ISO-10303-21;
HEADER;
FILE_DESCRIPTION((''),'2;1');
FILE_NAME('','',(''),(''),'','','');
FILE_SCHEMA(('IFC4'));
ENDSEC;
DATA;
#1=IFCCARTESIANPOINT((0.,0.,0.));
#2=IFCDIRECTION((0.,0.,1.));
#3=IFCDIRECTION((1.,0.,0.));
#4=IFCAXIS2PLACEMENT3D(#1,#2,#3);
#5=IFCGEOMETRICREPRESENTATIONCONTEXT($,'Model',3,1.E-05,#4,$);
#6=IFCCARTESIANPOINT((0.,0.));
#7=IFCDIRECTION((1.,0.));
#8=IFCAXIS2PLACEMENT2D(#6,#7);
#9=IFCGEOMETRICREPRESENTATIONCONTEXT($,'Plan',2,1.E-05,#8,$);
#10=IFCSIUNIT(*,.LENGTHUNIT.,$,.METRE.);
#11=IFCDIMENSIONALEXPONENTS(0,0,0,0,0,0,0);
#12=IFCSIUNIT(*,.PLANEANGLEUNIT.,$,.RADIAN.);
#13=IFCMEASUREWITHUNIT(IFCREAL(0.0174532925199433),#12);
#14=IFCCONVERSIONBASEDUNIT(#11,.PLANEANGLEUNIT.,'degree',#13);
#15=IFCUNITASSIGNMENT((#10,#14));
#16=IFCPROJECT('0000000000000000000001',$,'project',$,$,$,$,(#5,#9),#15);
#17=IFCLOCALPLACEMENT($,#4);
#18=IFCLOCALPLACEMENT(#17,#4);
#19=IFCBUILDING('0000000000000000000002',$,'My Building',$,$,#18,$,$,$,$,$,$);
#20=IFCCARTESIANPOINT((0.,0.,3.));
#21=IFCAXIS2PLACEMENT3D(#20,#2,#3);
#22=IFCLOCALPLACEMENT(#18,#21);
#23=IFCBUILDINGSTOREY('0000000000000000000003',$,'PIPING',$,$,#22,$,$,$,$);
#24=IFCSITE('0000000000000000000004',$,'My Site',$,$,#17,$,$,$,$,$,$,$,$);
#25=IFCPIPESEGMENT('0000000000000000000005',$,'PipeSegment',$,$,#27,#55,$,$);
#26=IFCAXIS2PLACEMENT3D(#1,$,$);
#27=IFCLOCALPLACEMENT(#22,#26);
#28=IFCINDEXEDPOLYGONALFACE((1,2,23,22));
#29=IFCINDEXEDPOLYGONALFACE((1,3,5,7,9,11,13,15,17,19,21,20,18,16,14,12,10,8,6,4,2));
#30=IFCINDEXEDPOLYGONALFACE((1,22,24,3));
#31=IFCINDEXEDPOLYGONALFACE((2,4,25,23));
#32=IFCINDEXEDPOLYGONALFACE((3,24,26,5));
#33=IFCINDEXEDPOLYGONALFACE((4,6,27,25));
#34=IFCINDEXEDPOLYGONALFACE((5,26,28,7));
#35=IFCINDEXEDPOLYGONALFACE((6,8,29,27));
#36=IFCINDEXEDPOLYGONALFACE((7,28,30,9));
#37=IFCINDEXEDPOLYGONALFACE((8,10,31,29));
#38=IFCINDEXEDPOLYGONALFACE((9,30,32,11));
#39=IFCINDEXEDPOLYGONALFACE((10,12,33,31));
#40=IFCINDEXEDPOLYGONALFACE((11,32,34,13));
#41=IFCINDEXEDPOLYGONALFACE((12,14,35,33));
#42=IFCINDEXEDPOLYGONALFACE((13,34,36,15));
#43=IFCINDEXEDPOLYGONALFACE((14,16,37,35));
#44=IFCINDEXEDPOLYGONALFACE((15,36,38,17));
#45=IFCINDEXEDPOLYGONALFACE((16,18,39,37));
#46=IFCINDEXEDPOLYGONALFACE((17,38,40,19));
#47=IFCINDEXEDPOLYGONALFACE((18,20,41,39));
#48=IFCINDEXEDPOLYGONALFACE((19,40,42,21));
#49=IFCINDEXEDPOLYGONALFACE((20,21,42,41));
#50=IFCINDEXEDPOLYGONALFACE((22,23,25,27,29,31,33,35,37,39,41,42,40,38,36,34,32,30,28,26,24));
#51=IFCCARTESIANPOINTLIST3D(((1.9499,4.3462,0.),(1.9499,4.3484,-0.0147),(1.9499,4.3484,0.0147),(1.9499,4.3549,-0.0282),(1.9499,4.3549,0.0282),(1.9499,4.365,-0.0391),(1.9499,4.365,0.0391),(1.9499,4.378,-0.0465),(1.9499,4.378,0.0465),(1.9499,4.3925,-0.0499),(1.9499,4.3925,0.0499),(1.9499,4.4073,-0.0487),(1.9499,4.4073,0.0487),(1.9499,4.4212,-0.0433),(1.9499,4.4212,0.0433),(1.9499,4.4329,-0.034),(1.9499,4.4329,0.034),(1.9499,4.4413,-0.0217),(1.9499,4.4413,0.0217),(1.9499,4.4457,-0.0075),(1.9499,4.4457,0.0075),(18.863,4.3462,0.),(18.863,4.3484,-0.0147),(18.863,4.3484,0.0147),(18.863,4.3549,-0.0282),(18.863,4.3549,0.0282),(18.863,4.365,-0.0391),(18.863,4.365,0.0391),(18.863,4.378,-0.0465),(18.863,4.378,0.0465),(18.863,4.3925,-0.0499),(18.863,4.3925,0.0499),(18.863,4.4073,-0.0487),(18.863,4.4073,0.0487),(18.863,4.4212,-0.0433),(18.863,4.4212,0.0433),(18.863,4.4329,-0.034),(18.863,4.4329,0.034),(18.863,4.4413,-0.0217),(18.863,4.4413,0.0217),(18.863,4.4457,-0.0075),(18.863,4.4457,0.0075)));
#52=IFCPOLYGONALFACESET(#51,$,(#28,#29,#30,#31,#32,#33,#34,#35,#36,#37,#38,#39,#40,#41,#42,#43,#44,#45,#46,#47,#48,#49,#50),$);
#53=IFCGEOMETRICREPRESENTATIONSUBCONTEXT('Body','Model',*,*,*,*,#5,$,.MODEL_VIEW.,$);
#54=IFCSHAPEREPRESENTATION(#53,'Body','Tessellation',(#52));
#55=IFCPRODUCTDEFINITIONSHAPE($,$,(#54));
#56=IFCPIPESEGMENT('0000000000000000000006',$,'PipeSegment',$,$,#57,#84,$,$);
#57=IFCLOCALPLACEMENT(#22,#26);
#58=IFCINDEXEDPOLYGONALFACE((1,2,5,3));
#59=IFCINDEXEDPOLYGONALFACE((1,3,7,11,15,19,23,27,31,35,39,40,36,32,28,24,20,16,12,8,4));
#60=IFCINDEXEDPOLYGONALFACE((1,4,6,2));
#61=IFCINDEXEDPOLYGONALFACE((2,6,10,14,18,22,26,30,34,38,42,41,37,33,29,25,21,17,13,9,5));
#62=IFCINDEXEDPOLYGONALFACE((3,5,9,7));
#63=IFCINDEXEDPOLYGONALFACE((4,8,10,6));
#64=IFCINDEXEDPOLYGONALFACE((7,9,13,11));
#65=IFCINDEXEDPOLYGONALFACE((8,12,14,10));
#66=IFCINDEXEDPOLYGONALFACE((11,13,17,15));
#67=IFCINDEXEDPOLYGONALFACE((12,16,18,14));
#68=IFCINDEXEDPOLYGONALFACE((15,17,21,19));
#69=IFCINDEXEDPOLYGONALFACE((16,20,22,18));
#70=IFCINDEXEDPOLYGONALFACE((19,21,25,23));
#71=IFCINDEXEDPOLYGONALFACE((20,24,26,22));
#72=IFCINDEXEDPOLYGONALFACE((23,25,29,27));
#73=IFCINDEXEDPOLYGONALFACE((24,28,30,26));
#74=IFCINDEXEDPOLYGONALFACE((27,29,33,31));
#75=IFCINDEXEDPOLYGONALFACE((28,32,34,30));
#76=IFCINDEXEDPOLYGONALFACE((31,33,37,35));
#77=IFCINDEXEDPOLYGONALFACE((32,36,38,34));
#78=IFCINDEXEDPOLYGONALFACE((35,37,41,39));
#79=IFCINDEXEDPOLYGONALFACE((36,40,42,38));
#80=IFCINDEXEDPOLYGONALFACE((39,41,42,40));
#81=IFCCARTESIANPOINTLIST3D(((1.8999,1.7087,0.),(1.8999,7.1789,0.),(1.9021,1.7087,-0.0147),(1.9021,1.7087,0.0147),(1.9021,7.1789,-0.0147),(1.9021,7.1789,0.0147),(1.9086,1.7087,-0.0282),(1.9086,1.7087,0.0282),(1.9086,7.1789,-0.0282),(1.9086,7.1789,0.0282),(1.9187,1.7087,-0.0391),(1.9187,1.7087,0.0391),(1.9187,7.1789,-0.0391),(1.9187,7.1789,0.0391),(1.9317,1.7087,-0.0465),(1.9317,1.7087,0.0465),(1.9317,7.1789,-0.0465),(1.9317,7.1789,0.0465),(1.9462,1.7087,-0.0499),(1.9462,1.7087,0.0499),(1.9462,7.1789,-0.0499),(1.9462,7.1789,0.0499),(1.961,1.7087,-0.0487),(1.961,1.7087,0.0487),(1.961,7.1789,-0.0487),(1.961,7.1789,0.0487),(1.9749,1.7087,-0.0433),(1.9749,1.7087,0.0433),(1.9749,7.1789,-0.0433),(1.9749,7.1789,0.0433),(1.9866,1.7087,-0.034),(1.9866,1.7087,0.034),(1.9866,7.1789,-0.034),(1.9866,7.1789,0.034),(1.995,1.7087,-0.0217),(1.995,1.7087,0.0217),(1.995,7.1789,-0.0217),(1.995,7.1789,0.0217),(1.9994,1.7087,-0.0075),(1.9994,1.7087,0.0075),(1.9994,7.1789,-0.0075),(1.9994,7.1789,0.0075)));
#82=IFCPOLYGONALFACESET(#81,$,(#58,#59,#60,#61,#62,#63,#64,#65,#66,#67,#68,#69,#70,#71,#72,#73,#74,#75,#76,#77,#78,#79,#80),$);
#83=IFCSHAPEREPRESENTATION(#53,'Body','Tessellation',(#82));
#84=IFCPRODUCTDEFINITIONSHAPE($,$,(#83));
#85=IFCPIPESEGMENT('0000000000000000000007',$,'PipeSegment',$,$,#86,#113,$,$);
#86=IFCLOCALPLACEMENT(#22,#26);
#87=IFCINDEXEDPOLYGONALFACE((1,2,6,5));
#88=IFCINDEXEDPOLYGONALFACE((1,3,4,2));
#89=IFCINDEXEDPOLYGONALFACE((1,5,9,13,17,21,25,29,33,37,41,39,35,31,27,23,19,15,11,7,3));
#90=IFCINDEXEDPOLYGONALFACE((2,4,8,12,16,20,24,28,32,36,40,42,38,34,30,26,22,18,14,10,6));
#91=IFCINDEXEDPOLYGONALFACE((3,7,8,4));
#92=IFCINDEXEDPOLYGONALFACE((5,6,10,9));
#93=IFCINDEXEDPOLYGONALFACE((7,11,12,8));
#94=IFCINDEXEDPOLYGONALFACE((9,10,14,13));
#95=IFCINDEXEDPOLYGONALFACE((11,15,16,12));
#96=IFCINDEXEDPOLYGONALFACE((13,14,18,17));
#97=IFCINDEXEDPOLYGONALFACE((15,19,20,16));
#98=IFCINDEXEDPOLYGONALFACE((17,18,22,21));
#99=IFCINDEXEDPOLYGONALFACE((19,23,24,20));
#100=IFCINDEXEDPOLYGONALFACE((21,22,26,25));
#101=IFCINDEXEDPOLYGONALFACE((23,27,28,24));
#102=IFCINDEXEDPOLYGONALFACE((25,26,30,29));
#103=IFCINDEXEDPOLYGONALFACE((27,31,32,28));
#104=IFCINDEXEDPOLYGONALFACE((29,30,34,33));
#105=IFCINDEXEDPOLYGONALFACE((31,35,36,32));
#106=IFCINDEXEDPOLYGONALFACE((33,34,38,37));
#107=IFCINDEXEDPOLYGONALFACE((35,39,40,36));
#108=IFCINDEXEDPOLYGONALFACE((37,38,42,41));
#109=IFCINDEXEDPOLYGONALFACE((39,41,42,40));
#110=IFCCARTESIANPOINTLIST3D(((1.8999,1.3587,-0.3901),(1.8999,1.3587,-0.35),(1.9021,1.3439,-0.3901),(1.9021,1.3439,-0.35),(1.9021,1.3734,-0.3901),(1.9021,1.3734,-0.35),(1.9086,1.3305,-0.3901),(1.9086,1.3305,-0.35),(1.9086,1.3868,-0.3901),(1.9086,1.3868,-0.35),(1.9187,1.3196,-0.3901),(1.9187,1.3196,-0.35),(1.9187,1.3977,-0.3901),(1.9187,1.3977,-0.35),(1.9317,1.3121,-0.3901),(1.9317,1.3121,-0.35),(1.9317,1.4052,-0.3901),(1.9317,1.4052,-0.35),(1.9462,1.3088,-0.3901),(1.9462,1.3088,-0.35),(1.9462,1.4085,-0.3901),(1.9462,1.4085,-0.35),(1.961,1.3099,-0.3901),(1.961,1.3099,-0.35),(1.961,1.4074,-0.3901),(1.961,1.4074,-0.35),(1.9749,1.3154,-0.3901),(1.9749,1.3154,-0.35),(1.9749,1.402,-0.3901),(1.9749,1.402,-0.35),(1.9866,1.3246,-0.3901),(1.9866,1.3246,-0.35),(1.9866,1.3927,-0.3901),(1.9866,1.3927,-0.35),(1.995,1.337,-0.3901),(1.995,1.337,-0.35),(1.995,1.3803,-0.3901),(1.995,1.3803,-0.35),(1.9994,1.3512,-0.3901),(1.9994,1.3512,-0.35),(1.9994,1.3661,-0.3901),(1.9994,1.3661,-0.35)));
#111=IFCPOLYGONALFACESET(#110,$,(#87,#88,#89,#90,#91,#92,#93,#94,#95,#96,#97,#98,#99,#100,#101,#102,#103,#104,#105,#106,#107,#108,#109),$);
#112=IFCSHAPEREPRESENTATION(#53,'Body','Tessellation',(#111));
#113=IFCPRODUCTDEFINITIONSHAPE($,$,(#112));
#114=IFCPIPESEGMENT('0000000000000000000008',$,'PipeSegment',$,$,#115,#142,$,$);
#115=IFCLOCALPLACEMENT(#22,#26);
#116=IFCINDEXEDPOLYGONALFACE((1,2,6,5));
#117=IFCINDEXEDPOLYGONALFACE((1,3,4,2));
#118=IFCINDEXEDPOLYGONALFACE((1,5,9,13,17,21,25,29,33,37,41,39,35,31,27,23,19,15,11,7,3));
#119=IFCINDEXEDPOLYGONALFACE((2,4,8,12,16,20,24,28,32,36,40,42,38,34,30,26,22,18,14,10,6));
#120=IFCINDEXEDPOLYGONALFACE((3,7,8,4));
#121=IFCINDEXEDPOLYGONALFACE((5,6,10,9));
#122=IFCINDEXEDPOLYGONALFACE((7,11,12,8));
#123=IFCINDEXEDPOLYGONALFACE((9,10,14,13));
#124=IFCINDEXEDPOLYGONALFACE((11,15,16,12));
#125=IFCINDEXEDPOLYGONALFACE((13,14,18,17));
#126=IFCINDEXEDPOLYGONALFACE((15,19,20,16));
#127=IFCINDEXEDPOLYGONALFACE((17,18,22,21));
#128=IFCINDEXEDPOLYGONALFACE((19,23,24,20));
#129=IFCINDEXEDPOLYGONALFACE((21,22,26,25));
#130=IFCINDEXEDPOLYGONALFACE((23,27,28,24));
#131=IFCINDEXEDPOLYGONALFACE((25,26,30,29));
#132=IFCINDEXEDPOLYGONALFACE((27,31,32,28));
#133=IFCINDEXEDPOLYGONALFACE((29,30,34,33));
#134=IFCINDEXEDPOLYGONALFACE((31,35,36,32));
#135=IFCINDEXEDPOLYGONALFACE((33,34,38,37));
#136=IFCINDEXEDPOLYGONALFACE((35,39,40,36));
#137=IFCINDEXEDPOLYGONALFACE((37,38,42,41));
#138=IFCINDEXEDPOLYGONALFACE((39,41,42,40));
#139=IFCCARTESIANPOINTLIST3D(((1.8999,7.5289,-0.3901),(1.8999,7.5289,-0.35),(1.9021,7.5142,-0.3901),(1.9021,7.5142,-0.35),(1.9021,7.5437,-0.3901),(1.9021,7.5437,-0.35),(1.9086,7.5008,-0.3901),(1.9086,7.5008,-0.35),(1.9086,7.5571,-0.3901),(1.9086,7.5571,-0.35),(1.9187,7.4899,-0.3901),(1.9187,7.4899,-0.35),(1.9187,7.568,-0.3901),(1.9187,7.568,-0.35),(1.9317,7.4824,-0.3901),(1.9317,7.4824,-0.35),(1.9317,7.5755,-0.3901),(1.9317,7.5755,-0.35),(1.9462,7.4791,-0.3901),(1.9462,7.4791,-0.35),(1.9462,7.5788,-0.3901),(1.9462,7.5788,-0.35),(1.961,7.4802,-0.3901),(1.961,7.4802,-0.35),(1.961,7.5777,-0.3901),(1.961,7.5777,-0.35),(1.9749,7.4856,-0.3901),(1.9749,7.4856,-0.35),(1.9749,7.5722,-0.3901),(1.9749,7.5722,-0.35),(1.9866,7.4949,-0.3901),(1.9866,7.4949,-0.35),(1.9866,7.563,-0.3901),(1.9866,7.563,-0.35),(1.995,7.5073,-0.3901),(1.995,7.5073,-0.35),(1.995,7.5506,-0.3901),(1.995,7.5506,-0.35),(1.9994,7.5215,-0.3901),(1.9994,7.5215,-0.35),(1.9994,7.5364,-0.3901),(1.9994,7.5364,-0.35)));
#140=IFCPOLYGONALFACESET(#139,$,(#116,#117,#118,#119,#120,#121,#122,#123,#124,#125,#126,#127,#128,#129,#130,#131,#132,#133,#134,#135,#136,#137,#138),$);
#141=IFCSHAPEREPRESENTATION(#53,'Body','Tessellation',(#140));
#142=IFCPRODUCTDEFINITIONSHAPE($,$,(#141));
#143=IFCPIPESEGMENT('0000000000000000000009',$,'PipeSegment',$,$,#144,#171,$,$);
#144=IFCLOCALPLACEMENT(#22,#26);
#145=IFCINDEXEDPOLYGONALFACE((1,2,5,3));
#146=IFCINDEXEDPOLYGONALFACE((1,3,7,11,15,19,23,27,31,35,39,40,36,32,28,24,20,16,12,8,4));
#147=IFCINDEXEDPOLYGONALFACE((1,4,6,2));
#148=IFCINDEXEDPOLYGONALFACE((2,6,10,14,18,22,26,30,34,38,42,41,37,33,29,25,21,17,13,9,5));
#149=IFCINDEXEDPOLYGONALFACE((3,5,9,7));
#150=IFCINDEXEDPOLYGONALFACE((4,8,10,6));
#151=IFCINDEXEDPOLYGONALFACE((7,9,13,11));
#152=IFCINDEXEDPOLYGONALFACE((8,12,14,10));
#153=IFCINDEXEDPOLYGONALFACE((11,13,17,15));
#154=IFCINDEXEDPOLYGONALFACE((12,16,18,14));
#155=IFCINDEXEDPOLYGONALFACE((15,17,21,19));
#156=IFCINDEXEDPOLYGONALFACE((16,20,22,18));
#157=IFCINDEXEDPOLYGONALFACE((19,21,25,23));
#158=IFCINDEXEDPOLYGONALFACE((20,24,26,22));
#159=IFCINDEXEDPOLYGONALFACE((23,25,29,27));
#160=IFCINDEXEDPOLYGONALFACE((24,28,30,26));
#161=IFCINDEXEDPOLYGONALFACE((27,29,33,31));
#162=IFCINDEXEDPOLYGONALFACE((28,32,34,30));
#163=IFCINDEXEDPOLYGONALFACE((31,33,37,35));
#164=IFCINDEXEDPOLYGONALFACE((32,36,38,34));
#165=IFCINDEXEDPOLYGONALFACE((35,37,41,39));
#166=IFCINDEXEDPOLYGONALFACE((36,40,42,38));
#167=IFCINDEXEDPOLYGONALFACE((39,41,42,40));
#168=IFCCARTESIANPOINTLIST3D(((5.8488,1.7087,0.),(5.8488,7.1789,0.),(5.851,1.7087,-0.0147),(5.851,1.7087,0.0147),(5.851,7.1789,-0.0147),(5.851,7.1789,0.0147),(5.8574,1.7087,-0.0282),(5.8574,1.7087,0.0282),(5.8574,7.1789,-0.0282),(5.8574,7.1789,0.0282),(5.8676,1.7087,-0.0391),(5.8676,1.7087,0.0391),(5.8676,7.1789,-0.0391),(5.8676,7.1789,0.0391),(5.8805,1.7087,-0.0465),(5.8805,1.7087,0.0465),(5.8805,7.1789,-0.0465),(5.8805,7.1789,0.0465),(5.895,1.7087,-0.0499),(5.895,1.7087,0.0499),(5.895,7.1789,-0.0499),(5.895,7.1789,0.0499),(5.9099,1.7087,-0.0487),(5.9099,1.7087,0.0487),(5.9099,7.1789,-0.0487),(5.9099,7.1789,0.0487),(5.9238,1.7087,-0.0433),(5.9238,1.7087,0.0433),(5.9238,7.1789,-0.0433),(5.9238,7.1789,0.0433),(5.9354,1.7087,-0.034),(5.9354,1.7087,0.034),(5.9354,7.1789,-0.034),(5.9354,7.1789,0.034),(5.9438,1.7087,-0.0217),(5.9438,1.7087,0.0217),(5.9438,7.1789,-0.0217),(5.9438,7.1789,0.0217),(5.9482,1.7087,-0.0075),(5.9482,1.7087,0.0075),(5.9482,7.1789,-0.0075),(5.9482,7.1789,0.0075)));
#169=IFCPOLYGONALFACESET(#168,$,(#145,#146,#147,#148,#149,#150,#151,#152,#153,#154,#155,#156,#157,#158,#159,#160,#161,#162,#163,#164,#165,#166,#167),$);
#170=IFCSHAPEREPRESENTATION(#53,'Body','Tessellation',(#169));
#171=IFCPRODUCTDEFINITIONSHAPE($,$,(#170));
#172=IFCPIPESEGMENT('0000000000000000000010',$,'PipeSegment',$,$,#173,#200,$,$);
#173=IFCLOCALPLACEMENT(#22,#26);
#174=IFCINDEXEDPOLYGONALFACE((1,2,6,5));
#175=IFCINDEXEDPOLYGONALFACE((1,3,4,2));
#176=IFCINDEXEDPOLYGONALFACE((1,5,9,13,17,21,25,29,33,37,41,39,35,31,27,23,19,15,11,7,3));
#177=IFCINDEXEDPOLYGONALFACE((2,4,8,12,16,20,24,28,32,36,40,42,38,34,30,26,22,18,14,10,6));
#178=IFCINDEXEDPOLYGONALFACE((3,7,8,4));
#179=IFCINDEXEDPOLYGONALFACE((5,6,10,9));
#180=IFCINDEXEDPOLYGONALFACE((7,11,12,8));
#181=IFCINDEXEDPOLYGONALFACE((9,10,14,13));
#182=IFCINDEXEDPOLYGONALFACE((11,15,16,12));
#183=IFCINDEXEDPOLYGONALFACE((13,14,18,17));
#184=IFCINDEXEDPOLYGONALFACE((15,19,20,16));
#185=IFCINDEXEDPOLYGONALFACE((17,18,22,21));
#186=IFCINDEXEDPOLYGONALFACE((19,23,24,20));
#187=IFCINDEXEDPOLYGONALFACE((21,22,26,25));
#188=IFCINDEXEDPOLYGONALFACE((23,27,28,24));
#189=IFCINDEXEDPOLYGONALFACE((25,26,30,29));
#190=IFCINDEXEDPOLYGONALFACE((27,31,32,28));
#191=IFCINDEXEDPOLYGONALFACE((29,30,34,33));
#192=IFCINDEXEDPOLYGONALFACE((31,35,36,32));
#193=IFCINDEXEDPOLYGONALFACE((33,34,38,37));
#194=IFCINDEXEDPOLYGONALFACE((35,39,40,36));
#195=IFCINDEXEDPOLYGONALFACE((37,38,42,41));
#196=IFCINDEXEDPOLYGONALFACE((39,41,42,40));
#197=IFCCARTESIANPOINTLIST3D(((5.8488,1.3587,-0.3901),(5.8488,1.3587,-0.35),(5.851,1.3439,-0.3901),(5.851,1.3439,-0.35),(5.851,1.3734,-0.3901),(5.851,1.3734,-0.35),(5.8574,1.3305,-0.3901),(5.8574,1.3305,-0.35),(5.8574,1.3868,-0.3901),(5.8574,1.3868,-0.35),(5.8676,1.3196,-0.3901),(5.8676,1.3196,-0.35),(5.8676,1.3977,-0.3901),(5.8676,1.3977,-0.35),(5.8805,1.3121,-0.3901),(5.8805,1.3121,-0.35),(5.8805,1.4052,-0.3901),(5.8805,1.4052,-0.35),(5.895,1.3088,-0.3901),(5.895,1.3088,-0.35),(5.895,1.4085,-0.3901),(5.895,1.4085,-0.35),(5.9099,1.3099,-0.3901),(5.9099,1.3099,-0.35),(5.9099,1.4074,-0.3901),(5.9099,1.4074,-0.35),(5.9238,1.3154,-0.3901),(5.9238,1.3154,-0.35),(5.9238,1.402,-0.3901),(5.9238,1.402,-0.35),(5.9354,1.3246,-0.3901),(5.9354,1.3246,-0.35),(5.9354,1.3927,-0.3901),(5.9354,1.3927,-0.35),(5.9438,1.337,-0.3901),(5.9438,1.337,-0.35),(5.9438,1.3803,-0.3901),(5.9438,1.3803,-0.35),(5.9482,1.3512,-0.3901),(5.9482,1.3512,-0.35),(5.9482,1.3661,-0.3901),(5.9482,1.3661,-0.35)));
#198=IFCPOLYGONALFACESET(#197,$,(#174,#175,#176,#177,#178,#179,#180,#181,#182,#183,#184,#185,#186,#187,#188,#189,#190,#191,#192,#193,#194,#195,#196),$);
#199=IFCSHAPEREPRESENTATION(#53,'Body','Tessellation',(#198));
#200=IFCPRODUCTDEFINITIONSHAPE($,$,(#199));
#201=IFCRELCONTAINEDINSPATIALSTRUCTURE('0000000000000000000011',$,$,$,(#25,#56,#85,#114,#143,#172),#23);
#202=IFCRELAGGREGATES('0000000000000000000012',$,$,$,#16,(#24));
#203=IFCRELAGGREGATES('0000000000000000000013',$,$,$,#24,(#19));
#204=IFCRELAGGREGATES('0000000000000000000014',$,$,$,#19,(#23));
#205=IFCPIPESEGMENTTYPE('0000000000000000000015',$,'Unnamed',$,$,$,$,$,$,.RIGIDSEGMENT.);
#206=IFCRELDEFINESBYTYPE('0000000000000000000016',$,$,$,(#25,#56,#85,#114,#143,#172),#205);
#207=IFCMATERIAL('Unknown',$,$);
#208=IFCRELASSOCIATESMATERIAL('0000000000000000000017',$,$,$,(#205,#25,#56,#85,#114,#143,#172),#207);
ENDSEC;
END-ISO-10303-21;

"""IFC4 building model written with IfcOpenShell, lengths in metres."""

from ifc_helpers import new_model, entity, si_unit, converted_unit, frame, origin_with_axes, origin_2d_with_axis, place, context, subcontext, project, spatial, circle, extrude, material, material_profile, profile_set, profile_usage, type_object, element, save


model = new_model("IFC4")

# Units and contexts
model_context = context("Model", 3, precision=1e-05, world=origin_with_axes())
plan_context = context("Plan", 2, precision=1e-05, world=origin_2d_with_axis())
body_context = subcontext(model_context, "Body", "Model", "MODEL_VIEW")
ifc_project = project(units=[si_unit("LENGTHUNIT", "METRE"), converted_unit("PLANEANGLEUNIT", "degree", entity("IfcReal", 0.0174532925199433), si_unit("PLANEANGLEUNIT", "RADIAN"), dimensions=[0, 0, 0, 0, 0, 0, 0])], contexts=[model_context, plan_context])

# Site, building, storey
site_placement = place(None, origin_with_axes())
site = spatial("IfcSite", under=ifc_project, at=site_placement, Name="My Site")
building_placement = place(site_placement, origin_with_axes())
building = spatial("IfcBuilding", under=site, at=building_placement, Name="My Building")
storey_placement = place(building_placement, frame((0.0, 0.0, 3.0), z_axis=(0.0, 0.0, 1.0), x_axis=(1.0, 0.0, 0.0)))
storey = spatial("IfcBuildingStorey", under=building, at=storey_placement, Name="PIPING")

# Pipe segments
ifc_material = material(Name="Unknown")
ifc_material_profile_1 = material_profile(ifc_material, circle(Radius=0.05))
ifc_profile_set_1 = profile_set([ifc_material_profile_1])
ifc_profile_usage_1 = profile_usage(ifc_profile_set_1, cardinal=5)
pipe_segment_type = type_object("IfcPipeSegmentType", Name="Unnamed", PredefinedType="RIGIDSEGMENT", material=ifc_profile_set_1)
pipe_segment_1_placement = place(storey_placement, frame((18.863, 4.3962, 0.0), z_axis=(-1.0, 0.0, 0.0), x_axis=(0.0, -1.0, 0.0)))
element("IfcPipeSegment", 1, at=pipe_segment_1_placement, inside=storey, type_object=pipe_segment_type, material=ifc_profile_usage_1, Name="PipeSegment", context=body_context, shape_type="SweptSolid", body=[
    extrude(circle(Radius=0.05), origin_with_axes(), (0.0, 0.0, 1.0), 16.9131),
])
ifc_profile_usage_2 = profile_usage(ifc_profile_set_1, cardinal=5)
pipe_segment_2_placement = place(storey_placement, frame((1.9499, 1.7087, 0.0), z_axis=(0.0, 1.0, 0.0), x_axis=(-1.0, 0.0, 0.0)))
element("IfcPipeSegment", 2, at=pipe_segment_2_placement, inside=storey, type_object=pipe_segment_type, material=ifc_profile_usage_2, Name="PipeSegment", context=body_context, shape_type="SweptSolid", body=[
    extrude(circle(Radius=0.05), origin_with_axes(), (0.0, 0.0, 1.0), 5.4703),
])
ifc_profile_usage_3 = profile_usage(ifc_profile_set_1, cardinal=5)
pipe_segment_3_placement = place(storey_placement, frame((1.9499, 1.3587, -0.35), z_axis=(0.0, 0.0, -1.0), x_axis=(-1.0, 0.0, 0.0)))
element("IfcPipeSegment", 3, at=pipe_segment_3_placement, inside=storey, type_object=pipe_segment_type, material=ifc_profile_usage_3, Name="PipeSegment", context=body_context, shape_type="SweptSolid", body=[
    extrude(circle(Radius=0.05), origin_with_axes(), (0.0, 0.0, 1.0), 0.0401),
])
ifc_profile_usage_4 = profile_usage(ifc_profile_set_1, cardinal=5)
pipe_segment_4_placement = place(storey_placement, frame((1.9499, 7.5289, -0.35), z_axis=(0.0, 0.0, -1.0), x_axis=(-1.0, 0.0, 0.0)))
element("IfcPipeSegment", 4, at=pipe_segment_4_placement, inside=storey, type_object=pipe_segment_type, material=ifc_profile_usage_4, Name="PipeSegment", context=body_context, shape_type="SweptSolid", body=[
    extrude(circle(Radius=0.05), origin_with_axes(), (0.0, 0.0, 1.0), 0.0401),
])
ifc_profile_usage_5 = profile_usage(ifc_profile_set_1, cardinal=5)
pipe_segment_5_placement = place(storey_placement, frame((5.8988, 1.7087, 0.0), z_axis=(0.0, 1.0, 0.0), x_axis=(-1.0, 0.0, 0.0)))
element("IfcPipeSegment", 5, at=pipe_segment_5_placement, inside=storey, type_object=pipe_segment_type, material=ifc_profile_usage_5, Name="PipeSegment", context=body_context, shape_type="SweptSolid", body=[
    extrude(circle(Radius=0.05), origin_with_axes(), (0.0, 0.0, 1.0), 5.4703),
])
ifc_profile_usage_6 = profile_usage(ifc_profile_set_1, cardinal=5)
pipe_segment_6_placement = place(storey_placement, frame((5.8988, 1.3587, -0.35), z_axis=(0.0, 0.0, -1.0), x_axis=(-1.0, 0.0, 0.0)))
element("IfcPipeSegment", 6, at=pipe_segment_6_placement, inside=storey, type_object=pipe_segment_type, material=ifc_profile_usage_6, Name="PipeSegment", context=body_context, shape_type="SweptSolid", body=[
    extrude(circle(Radius=0.05), origin_with_axes(), (0.0, 0.0, 1.0), 0.0401),
])

save(model, "model.ifc")
